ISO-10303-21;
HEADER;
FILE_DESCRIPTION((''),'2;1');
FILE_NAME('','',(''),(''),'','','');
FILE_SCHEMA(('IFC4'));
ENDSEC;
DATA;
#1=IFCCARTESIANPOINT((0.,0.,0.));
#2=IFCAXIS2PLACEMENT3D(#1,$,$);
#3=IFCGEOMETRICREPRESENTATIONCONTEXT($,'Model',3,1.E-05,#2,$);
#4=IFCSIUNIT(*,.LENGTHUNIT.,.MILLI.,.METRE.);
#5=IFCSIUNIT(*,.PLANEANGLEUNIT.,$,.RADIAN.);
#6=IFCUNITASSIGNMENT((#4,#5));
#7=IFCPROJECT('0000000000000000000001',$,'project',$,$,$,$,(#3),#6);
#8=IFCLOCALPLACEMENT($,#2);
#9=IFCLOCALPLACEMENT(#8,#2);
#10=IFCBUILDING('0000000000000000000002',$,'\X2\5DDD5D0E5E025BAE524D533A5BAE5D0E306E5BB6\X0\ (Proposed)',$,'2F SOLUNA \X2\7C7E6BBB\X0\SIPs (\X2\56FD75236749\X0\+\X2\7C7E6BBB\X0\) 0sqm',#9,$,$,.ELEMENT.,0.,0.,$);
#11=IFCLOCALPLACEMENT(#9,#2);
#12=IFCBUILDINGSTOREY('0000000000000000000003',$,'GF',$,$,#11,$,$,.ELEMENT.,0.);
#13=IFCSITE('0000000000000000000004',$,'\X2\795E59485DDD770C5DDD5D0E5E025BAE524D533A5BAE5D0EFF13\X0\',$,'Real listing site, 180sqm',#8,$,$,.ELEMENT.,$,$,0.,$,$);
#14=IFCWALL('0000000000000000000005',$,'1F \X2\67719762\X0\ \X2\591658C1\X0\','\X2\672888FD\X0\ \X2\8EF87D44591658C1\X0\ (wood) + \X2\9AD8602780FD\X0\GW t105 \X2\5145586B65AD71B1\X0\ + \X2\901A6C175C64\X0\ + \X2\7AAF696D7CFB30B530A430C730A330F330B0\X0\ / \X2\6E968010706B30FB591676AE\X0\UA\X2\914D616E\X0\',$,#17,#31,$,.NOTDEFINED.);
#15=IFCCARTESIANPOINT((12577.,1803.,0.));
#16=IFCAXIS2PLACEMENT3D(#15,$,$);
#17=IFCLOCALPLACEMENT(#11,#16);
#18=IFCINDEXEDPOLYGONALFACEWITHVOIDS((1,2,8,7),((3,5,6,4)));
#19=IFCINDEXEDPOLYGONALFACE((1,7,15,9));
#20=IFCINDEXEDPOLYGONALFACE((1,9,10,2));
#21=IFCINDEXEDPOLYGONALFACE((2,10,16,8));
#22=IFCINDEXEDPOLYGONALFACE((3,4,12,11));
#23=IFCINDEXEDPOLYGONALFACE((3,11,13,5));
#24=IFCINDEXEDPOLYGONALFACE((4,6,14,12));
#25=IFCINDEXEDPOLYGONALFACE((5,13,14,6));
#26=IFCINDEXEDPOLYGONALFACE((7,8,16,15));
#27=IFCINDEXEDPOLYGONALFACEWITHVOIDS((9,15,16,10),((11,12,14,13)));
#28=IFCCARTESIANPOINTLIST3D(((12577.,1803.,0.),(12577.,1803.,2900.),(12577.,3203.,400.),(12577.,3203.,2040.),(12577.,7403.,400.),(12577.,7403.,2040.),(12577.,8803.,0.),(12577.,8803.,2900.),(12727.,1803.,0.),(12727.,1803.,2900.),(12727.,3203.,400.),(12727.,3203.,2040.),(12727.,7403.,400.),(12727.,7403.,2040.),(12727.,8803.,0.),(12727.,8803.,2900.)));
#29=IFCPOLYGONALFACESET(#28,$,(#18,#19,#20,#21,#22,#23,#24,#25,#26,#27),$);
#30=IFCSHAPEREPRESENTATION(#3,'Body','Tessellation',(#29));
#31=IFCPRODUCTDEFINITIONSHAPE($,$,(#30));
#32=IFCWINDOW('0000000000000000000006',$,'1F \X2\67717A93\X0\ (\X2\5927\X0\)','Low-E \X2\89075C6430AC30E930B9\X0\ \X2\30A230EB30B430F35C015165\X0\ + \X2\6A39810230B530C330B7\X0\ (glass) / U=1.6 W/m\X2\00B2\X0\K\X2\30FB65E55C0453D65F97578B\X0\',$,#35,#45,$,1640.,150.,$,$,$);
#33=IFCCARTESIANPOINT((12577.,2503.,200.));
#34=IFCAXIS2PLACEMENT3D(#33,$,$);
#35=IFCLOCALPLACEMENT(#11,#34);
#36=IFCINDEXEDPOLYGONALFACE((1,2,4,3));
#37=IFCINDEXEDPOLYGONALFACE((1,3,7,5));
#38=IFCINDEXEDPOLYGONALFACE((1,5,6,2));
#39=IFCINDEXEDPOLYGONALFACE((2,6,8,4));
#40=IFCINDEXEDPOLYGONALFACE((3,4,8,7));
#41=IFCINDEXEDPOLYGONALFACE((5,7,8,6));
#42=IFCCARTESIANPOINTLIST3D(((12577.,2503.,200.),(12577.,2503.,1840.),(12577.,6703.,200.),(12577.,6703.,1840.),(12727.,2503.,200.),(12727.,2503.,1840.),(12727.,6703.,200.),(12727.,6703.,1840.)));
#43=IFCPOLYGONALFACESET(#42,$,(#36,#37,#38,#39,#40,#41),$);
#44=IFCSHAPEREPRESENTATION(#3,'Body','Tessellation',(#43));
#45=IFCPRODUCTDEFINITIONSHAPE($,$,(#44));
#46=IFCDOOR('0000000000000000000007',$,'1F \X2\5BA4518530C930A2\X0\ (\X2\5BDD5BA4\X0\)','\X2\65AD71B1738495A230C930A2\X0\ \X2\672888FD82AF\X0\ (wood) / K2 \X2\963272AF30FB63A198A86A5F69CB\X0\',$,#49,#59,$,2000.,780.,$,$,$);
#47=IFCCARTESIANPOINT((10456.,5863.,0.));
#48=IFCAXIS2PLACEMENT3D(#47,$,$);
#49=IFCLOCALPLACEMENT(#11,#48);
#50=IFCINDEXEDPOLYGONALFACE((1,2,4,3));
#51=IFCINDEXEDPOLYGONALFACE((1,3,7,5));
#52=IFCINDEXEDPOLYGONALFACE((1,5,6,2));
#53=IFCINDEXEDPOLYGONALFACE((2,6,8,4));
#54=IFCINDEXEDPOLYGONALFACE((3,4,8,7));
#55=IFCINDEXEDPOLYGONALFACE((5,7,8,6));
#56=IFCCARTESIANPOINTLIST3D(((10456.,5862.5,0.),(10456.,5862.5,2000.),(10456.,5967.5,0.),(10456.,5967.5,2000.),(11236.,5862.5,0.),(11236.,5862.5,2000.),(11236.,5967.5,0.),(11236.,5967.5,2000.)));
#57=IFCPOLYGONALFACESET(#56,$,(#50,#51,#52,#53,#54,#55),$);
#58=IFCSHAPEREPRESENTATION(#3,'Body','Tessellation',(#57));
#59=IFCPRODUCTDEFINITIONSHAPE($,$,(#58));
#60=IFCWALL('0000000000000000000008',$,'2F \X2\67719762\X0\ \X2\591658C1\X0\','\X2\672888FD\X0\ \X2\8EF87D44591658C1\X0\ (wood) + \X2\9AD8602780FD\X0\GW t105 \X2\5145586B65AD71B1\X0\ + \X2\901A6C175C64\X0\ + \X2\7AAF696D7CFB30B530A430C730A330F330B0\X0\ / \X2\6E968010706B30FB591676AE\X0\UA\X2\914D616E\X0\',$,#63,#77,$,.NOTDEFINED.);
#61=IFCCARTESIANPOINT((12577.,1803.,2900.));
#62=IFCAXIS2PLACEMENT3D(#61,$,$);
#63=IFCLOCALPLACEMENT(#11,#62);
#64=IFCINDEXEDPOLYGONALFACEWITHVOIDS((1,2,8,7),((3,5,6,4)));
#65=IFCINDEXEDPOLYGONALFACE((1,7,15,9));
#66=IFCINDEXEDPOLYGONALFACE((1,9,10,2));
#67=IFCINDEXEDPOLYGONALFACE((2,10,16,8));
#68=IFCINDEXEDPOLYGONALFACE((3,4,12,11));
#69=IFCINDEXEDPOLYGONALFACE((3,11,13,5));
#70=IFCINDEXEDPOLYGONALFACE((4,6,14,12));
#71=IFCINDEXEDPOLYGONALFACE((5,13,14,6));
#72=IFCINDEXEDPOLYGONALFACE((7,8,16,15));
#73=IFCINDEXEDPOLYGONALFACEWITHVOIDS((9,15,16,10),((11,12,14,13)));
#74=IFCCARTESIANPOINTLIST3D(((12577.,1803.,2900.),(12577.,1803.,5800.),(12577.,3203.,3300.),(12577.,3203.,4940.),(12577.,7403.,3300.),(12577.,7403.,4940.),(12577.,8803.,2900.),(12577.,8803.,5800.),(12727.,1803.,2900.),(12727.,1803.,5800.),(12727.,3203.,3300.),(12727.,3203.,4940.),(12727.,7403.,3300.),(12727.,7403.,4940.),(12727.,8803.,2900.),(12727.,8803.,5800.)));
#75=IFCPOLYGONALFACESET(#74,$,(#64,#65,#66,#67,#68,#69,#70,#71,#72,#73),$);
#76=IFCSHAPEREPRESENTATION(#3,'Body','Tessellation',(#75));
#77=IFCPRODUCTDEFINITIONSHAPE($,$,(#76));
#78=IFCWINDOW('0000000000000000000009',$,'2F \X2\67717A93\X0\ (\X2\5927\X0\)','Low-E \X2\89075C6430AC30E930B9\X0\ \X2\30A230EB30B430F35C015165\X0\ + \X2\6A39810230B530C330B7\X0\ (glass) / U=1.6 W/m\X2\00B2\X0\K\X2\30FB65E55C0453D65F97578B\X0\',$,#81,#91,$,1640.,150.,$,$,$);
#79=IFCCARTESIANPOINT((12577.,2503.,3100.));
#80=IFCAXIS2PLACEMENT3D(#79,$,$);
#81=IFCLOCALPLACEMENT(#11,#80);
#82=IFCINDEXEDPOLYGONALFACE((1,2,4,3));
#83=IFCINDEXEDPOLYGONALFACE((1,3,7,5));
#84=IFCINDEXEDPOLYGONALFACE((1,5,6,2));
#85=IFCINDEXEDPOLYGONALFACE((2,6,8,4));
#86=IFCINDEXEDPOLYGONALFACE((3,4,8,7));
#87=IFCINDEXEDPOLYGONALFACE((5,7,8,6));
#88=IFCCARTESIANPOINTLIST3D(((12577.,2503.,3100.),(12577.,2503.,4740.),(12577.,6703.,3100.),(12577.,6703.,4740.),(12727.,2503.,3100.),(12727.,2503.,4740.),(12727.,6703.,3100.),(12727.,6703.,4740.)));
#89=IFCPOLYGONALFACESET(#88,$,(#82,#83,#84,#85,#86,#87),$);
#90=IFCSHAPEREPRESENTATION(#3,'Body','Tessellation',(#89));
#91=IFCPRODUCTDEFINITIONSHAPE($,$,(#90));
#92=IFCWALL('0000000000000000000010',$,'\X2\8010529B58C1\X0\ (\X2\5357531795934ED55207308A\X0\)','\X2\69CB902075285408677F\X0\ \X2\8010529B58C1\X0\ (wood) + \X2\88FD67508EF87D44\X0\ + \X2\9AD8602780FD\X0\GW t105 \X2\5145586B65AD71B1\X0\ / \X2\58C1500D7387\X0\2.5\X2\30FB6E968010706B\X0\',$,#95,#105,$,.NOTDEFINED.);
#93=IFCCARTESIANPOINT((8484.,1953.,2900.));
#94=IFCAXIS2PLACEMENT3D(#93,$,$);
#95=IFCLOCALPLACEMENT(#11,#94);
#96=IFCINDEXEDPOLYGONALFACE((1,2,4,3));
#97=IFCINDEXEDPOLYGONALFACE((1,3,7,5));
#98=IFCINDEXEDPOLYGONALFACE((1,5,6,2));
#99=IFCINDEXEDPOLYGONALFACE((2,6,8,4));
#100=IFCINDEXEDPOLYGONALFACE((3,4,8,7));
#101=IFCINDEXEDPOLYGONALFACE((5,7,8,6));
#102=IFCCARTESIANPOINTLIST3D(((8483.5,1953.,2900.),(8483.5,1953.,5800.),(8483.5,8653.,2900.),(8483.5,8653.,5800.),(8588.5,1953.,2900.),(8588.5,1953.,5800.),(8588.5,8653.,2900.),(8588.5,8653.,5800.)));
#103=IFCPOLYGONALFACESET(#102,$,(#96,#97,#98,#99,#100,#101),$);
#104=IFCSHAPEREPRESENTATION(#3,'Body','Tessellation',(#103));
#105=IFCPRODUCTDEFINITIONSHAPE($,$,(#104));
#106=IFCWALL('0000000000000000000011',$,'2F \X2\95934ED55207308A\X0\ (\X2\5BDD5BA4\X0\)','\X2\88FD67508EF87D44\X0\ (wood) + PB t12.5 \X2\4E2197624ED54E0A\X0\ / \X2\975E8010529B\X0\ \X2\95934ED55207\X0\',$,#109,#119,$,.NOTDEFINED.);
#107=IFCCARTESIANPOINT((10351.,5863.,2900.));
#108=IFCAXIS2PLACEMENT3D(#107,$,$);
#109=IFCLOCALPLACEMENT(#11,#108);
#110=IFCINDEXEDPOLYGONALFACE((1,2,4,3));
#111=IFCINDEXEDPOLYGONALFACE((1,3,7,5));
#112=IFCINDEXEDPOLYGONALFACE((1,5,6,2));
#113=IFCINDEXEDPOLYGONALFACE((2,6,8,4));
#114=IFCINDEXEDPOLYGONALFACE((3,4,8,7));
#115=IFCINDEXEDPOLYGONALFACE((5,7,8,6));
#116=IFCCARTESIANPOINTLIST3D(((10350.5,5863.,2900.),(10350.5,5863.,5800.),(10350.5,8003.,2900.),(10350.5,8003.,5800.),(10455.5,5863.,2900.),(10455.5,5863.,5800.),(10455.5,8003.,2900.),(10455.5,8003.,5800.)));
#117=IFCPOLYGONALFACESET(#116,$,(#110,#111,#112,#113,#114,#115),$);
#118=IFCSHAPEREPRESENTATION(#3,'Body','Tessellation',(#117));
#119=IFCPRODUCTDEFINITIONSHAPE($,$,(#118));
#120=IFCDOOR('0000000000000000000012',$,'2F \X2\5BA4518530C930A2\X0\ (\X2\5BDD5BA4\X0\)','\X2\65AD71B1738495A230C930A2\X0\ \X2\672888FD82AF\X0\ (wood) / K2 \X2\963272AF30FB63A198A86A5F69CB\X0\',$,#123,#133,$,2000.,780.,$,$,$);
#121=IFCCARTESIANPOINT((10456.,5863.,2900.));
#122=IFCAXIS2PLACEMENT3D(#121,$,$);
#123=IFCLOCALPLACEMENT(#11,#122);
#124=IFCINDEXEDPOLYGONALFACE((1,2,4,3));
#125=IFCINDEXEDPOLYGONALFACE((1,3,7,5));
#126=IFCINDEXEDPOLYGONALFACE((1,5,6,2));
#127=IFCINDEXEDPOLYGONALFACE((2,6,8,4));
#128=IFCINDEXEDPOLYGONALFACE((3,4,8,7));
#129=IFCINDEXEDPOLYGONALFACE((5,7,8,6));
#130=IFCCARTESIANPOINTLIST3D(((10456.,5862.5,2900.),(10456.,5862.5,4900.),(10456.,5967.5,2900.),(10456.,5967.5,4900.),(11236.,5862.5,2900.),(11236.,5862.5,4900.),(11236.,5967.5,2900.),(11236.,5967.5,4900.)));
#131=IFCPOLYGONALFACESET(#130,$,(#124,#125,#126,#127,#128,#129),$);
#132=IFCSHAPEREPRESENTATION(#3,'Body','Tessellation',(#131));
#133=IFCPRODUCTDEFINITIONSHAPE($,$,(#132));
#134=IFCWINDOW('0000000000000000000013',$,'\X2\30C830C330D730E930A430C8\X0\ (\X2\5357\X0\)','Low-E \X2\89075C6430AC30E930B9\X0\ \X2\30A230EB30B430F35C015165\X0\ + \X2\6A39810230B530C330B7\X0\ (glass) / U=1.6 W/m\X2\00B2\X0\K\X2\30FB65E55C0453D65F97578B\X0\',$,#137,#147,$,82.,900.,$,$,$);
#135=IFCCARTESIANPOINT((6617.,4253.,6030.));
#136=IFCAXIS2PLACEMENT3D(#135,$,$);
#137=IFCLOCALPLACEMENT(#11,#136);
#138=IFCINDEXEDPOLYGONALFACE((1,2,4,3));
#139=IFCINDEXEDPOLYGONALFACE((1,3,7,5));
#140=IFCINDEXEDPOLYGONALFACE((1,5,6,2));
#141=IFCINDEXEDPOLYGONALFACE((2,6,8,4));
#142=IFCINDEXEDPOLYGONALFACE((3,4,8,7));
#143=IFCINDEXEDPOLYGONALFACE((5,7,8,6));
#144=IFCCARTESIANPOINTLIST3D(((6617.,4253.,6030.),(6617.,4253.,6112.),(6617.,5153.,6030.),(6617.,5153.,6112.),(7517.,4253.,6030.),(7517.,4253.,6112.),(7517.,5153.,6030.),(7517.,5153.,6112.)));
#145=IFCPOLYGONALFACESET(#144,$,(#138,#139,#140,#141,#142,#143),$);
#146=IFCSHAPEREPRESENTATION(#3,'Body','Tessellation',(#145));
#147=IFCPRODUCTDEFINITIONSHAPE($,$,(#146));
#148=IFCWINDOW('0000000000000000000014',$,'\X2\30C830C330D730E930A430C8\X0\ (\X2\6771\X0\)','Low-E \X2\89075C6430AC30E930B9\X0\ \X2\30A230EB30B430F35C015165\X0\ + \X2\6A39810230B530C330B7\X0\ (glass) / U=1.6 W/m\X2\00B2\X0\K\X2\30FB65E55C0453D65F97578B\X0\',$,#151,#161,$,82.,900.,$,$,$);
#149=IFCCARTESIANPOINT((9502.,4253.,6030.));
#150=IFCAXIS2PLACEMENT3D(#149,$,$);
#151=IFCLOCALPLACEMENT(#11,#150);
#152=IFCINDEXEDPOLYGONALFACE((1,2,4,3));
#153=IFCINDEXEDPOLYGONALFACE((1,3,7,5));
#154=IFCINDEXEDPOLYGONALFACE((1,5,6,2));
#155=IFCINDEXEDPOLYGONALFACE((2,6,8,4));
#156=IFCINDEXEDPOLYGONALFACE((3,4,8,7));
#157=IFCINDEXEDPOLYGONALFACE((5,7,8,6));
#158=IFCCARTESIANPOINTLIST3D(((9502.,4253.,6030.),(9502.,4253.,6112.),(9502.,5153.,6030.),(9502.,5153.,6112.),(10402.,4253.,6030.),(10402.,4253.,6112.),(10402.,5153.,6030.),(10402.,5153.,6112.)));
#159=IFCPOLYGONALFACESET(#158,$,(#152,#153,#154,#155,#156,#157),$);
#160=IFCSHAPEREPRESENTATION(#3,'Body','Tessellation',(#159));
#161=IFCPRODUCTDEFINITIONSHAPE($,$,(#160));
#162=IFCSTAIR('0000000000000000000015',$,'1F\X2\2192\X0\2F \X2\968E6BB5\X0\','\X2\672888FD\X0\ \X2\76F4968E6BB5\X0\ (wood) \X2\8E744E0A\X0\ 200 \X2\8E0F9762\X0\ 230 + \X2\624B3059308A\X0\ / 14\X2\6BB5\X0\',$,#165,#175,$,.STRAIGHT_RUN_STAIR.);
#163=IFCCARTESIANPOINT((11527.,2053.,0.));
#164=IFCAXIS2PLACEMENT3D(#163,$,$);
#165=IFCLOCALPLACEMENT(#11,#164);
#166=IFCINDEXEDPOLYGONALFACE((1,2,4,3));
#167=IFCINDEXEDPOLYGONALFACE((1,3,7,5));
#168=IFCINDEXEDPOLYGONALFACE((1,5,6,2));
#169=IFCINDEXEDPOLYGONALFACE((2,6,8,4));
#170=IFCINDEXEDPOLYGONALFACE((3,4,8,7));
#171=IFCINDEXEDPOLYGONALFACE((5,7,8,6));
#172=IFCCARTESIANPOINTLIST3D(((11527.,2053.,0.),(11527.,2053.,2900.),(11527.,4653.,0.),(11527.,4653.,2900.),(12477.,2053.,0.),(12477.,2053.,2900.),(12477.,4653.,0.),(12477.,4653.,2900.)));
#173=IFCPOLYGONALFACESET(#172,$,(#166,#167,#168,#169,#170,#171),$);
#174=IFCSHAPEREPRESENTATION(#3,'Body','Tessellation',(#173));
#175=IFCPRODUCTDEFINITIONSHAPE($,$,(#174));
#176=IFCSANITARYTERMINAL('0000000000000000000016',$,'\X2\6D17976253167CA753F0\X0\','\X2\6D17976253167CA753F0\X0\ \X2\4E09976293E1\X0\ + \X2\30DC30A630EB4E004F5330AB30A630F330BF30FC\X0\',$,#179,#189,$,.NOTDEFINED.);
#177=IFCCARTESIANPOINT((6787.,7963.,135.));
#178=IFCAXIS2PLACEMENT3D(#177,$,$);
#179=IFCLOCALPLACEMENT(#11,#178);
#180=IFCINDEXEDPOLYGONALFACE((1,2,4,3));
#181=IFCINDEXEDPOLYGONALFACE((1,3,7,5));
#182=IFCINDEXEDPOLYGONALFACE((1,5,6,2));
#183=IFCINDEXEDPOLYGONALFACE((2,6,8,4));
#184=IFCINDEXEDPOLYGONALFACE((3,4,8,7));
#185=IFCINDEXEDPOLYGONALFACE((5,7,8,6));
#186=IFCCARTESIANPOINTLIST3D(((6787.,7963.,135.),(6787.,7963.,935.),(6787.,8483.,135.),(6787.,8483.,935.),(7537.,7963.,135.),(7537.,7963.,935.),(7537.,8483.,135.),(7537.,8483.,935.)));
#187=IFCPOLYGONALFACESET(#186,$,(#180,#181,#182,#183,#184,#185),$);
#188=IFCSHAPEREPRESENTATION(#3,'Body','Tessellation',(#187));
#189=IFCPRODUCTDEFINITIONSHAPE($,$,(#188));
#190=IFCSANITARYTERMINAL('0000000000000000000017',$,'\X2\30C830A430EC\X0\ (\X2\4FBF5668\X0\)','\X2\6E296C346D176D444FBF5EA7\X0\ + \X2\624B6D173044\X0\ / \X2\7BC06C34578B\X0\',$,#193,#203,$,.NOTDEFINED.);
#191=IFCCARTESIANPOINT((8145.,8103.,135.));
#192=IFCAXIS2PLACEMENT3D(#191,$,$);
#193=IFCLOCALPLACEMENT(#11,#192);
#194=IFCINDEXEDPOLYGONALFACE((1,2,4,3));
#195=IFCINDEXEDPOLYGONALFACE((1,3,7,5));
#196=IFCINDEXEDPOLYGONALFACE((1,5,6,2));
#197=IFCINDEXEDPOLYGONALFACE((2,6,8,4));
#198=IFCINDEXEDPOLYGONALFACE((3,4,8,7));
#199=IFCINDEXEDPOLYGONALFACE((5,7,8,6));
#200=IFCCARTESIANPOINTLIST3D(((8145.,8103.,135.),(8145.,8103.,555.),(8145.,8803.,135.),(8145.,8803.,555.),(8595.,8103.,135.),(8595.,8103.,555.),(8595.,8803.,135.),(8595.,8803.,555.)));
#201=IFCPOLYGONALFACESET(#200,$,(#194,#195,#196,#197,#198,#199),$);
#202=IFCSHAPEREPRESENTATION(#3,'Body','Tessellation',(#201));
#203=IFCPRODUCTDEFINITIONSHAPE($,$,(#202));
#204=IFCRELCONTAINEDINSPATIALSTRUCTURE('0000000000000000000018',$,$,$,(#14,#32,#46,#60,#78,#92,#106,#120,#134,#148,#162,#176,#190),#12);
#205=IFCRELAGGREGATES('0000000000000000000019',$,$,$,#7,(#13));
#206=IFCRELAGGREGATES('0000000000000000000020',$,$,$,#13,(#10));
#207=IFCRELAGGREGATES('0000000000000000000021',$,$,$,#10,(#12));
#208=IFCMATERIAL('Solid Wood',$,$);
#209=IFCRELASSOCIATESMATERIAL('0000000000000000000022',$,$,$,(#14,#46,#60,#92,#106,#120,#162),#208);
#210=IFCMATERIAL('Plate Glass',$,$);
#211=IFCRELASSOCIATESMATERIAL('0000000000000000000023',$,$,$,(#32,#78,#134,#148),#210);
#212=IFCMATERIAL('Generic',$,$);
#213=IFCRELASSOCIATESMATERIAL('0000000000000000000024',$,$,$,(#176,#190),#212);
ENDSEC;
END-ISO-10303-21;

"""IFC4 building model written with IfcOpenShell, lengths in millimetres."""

from ifc_helpers import new_model, si_unit, frame, frame_2d, origin, place, context, project, spatial, rectangle, extrude, material, element, fill, save


model = new_model("IFC4")

# Units and contexts
model_context = context("Model", 3, precision=1e-05, world=origin())
ifc_project = project(units=[si_unit("LENGTHUNIT", "METRE", prefix="MILLI"), si_unit("PLANEANGLEUNIT", "RADIAN")], contexts=[model_context])

# Site, building, storey
site_placement = place(None, origin())
site = spatial("IfcSite", under=ifc_project, at=site_placement, Name="神奈川県川崎市宮前区宮崎３", ObjectType="Real listing site, 180sqm", CompositionType="ELEMENT", RefElevation=0.0)
building_placement = place(site_placement, origin())
building = spatial("IfcBuilding", under=site, at=building_placement, Name="川崎市宮前区宮崎の家 (Proposed)", ObjectType="2F SOLUNA 籾殻SIPs (国産杉+籾殻) 0sqm", CompositionType="ELEMENT", ElevationOfRefHeight=0.0, ElevationOfTerrain=0.0)
storey_placement = place(building_placement, origin())
storey = spatial("IfcBuildingStorey", under=building, at=storey_placement, Name="GF", CompositionType="ELEMENT", Elevation=0.0)

# Wall, opening, window
ifc_material_1 = material(Name="Solid Wood")
wall_1_placement = place(storey_placement, frame((12577.0, 1803.0, 0.0)))
wall_1 = element("IfcWall", 1, at=wall_1_placement, inside=storey, material=ifc_material_1, Name="1F 東面 外壁", Description="木製 軸組外壁 (wood) + 高性能GW t105 充填断熱 + 通気層 + 窯業系サイディング / 準耐火・外皮UA配慮", PredefinedType="NOTDEFINED", context=model_context, shape_type="SweptSolid", body=[
    extrude(rectangle(XDim=150.0, YDim=7000.0, at=frame_2d((75.0, 3500.0))), frame((12577.0, 1803.0, 0.0)), (0.0, 0.0, 1.0), 2900.0),
])
opening_1_placement = place(storey_placement, frame((12577.0, 2503.0, 200.0)))
opening_1 = element("IfcOpeningElement", 2, at=opening_1_placement, cuts=wall_1, PredefinedType="NOTDEFINED", context=model_context, shape_type="SweptSolid", body=[
    extrude(rectangle(XDim=150.0, YDim=4200.0, at=frame_2d((75.0, 2100.0))), frame((12577.0, 2503.0, 200.0)), (0.0, 0.0, 1.0), 1640.0),
])
ifc_material_2 = material(Name="Plate Glass")
window_1_placement = place(storey_placement, frame((12577.0, 2503.0, 200.0)))
window_1 = element("IfcWindow", 3, at=window_1_placement, inside=storey, material=ifc_material_2, Name="1F 東窓 (大)", Description="Low-E 複層ガラス アルゴン封入 + 樹脂サッシ (glass) / U=1.6 W/m²K・日射取得型", OverallHeight=1640.0, OverallWidth=150.0, context=model_context, shape_type="SweptSolid", body=[
    extrude(rectangle(XDim=150.0, YDim=4200.0, at=frame_2d((75.0, 2100.0))), frame((12577.0, 2503.0, 200.0)), (0.0, 0.0, 1.0), 1640.0),
])
fill(opening_1, window_1)

# Door
door_1_placement = place(storey_placement, frame((10456.0, 5863.0, 0.0)))
element("IfcDoor", 4, at=door_1_placement, inside=storey, material=ifc_material_1, Name="1F 室内ドア (寝室)", Description="断熱玄関ドア 木製芯 (wood) / K2 防犯・採風機構", OverallHeight=2000.0, OverallWidth=780.0, context=model_context, shape_type="SweptSolid", body=[
    extrude(rectangle(XDim=780.0, YDim=105.0, at=frame_2d((390.0, 52.0))), frame((10456.0, 5863.0, 0.0)), (0.0, 0.0, 1.0), 2000.0),
])

# Wall, opening, window
wall_2_placement = place(storey_placement, frame((12577.0, 1803.0, 2900.0)))
wall_2 = element("IfcWall", 5, at=wall_2_placement, inside=storey, material=ifc_material_1, Name="2F 東面 外壁", Description="木製 軸組外壁 (wood) + 高性能GW t105 充填断熱 + 通気層 + 窯業系サイディング / 準耐火・外皮UA配慮", PredefinedType="NOTDEFINED", context=model_context, shape_type="SweptSolid", body=[
    extrude(rectangle(XDim=150.0, YDim=7000.0, at=frame_2d((75.0, 3500.0))), frame((12577.0, 1803.0, 2900.0)), (0.0, 0.0, 1.0), 2900.0),
])
opening_2_placement = place(storey_placement, frame((12577.0, 2503.0, 3100.0)))
opening_2 = element("IfcOpeningElement", 6, at=opening_2_placement, cuts=wall_2, PredefinedType="NOTDEFINED", context=model_context, shape_type="SweptSolid", body=[
    extrude(rectangle(XDim=150.0, YDim=4200.0, at=frame_2d((75.0, 2100.0))), frame((12577.0, 2503.0, 3100.0)), (0.0, 0.0, 1.0), 1640.0),
])
window_2_placement = place(storey_placement, frame((12577.0, 2503.0, 3100.0)))
window_2 = element("IfcWindow", 7, at=window_2_placement, inside=storey, material=ifc_material_2, Name="2F 東窓 (大)", Description="Low-E 複層ガラス アルゴン封入 + 樹脂サッシ (glass) / U=1.6 W/m²K・日射取得型", OverallHeight=1640.0, OverallWidth=150.0, context=model_context, shape_type="SweptSolid", body=[
    extrude(rectangle(XDim=150.0, YDim=4200.0, at=frame_2d((75.0, 2100.0))), frame((12577.0, 2503.0, 3100.0)), (0.0, 0.0, 1.0), 1640.0),
])
fill(opening_2, window_2)

# Walls
wall_3_placement = place(storey_placement, frame((8484.0, 1953.0, 2900.0)))
element("IfcWall", 8, at=wall_3_placement, inside=storey, material=ifc_material_1, Name="耐力壁 (南北間仕切り)", Description="構造用合板 耐力壁 (wood) + 製材軸組 + 高性能GW t105 充填断熱 / 壁倍率2.5・準耐火", PredefinedType="NOTDEFINED", context=model_context, shape_type="SweptSolid", body=[
    extrude(rectangle(XDim=105.0, YDim=6700.0, at=frame_2d((52.0, 3350.0))), frame((8484.0, 1953.0, 2900.0)), (0.0, 0.0, 1.0), 2900.0),
])
wall_4_placement = place(storey_placement, frame((10351.0, 5863.0, 2900.0)))
element("IfcWall", 9, at=wall_4_placement, inside=storey, material=ifc_material_1, Name="2F 間仕切り (寝室)", Description="製材軸組 (wood) + PB t12.5 両面仕上 / 非耐力 間仕切", PredefinedType="NOTDEFINED", context=model_context, shape_type="SweptSolid", body=[
    extrude(rectangle(XDim=105.0, YDim=2140.0, at=frame_2d((52.0, 1070.0))), frame((10351.0, 5863.0, 2900.0)), (0.0, 0.0, 1.0), 2900.0),
])

# Door
door_2_placement = place(storey_placement, frame((10456.0, 5863.0, 2900.0)))
element("IfcDoor", 10, at=door_2_placement, inside=storey, material=ifc_material_1, Name="2F 室内ドア (寝室)", Description="断熱玄関ドア 木製芯 (wood) / K2 防犯・採風機構", OverallHeight=2000.0, OverallWidth=780.0, context=model_context, shape_type="SweptSolid", body=[
    extrude(rectangle(XDim=780.0, YDim=105.0, at=frame_2d((390.0, 52.0))), frame((10456.0, 5863.0, 2900.0)), (0.0, 0.0, 1.0), 2000.0),
])

# Windows
window_3_placement = place(storey_placement, frame((6617.0, 4253.0, 6030.0)))
element("IfcWindow", 11, at=window_3_placement, inside=storey, material=ifc_material_2, Name="トップライト (南)", Description="Low-E 複層ガラス アルゴン封入 + 樹脂サッシ (glass) / U=1.6 W/m²K・日射取得型", OverallHeight=82.0, OverallWidth=900.0, context=model_context, shape_type="SweptSolid", body=[
    extrude(rectangle(XDim=900.0, YDim=900.0, at=frame_2d((450.0, 450.0))), frame((6617.0, 4253.0, 6030.0)), (0.0, 0.0, 1.0), 82.0),
])
window_4_placement = place(storey_placement, frame((9502.0, 4253.0, 6030.0)))
element("IfcWindow", 12, at=window_4_placement, inside=storey, material=ifc_material_2, Name="トップライト (東)", Description="Low-E 複層ガラス アルゴン封入 + 樹脂サッシ (glass) / U=1.6 W/m²K・日射取得型", OverallHeight=82.0, OverallWidth=900.0, context=model_context, shape_type="SweptSolid", body=[
    extrude(rectangle(XDim=900.0, YDim=900.0, at=frame_2d((450.0, 450.0))), frame((9502.0, 4253.0, 6030.0)), (0.0, 0.0, 1.0), 82.0),
])

# Stair
stair_placement = place(storey_placement, frame((11527.0, 2053.0, 0.0)))
element("IfcStair", 13, at=stair_placement, inside=storey, material=ifc_material_1, Name="1F→2F 階段", Description="木製 直階段 (wood) 蹴上 200 踏面 230 + 手すり / 14段", PredefinedType="STRAIGHT_RUN_STAIR", context=model_context, shape_type="SweptSolid", body=[
    extrude(rectangle(XDim=950.0, YDim=2600.0, at=frame_2d((475.0, 1300.0))), frame((11527.0, 2053.0, 0.0)), (0.0, 0.0, 1.0), 2900.0),
])

# Sanitary terminals
ifc_material_3 = material(Name="Generic")
sanitary_terminal_1_placement = place(storey_placement, frame((6787.0, 7963.0, 135.0)))
element("IfcSanitaryTerminal", 14, at=sanitary_terminal_1_placement, inside=storey, material=ifc_material_3, Name="洗面化粧台", Description="洗面化粧台 三面鏡 + ボウル一体カウンター", PredefinedType="NOTDEFINED", context=model_context, shape_type="SweptSolid", body=[
    extrude(rectangle(XDim=750.0, YDim=520.0, at=frame_2d((375.0, 260.0))), frame((6787.0, 7963.0, 135.0)), (0.0, 0.0, 1.0), 800.0),
])
sanitary_terminal_2_placement = place(storey_placement, frame((8145.0, 8103.0, 135.0)))
element("IfcSanitaryTerminal", 15, at=sanitary_terminal_2_placement, inside=storey, material=ifc_material_3, Name="トイレ (便器)", Description="温水洗浄便座 + 手洗い / 節水型", PredefinedType="NOTDEFINED", context=model_context, shape_type="SweptSolid", body=[
    extrude(rectangle(XDim=450.0, YDim=700.0, at=frame_2d((225.0, 350.0))), frame((8145.0, 8103.0, 135.0)), (0.0, 0.0, 1.0), 420.0),
])

save(model, "model.ifc")
